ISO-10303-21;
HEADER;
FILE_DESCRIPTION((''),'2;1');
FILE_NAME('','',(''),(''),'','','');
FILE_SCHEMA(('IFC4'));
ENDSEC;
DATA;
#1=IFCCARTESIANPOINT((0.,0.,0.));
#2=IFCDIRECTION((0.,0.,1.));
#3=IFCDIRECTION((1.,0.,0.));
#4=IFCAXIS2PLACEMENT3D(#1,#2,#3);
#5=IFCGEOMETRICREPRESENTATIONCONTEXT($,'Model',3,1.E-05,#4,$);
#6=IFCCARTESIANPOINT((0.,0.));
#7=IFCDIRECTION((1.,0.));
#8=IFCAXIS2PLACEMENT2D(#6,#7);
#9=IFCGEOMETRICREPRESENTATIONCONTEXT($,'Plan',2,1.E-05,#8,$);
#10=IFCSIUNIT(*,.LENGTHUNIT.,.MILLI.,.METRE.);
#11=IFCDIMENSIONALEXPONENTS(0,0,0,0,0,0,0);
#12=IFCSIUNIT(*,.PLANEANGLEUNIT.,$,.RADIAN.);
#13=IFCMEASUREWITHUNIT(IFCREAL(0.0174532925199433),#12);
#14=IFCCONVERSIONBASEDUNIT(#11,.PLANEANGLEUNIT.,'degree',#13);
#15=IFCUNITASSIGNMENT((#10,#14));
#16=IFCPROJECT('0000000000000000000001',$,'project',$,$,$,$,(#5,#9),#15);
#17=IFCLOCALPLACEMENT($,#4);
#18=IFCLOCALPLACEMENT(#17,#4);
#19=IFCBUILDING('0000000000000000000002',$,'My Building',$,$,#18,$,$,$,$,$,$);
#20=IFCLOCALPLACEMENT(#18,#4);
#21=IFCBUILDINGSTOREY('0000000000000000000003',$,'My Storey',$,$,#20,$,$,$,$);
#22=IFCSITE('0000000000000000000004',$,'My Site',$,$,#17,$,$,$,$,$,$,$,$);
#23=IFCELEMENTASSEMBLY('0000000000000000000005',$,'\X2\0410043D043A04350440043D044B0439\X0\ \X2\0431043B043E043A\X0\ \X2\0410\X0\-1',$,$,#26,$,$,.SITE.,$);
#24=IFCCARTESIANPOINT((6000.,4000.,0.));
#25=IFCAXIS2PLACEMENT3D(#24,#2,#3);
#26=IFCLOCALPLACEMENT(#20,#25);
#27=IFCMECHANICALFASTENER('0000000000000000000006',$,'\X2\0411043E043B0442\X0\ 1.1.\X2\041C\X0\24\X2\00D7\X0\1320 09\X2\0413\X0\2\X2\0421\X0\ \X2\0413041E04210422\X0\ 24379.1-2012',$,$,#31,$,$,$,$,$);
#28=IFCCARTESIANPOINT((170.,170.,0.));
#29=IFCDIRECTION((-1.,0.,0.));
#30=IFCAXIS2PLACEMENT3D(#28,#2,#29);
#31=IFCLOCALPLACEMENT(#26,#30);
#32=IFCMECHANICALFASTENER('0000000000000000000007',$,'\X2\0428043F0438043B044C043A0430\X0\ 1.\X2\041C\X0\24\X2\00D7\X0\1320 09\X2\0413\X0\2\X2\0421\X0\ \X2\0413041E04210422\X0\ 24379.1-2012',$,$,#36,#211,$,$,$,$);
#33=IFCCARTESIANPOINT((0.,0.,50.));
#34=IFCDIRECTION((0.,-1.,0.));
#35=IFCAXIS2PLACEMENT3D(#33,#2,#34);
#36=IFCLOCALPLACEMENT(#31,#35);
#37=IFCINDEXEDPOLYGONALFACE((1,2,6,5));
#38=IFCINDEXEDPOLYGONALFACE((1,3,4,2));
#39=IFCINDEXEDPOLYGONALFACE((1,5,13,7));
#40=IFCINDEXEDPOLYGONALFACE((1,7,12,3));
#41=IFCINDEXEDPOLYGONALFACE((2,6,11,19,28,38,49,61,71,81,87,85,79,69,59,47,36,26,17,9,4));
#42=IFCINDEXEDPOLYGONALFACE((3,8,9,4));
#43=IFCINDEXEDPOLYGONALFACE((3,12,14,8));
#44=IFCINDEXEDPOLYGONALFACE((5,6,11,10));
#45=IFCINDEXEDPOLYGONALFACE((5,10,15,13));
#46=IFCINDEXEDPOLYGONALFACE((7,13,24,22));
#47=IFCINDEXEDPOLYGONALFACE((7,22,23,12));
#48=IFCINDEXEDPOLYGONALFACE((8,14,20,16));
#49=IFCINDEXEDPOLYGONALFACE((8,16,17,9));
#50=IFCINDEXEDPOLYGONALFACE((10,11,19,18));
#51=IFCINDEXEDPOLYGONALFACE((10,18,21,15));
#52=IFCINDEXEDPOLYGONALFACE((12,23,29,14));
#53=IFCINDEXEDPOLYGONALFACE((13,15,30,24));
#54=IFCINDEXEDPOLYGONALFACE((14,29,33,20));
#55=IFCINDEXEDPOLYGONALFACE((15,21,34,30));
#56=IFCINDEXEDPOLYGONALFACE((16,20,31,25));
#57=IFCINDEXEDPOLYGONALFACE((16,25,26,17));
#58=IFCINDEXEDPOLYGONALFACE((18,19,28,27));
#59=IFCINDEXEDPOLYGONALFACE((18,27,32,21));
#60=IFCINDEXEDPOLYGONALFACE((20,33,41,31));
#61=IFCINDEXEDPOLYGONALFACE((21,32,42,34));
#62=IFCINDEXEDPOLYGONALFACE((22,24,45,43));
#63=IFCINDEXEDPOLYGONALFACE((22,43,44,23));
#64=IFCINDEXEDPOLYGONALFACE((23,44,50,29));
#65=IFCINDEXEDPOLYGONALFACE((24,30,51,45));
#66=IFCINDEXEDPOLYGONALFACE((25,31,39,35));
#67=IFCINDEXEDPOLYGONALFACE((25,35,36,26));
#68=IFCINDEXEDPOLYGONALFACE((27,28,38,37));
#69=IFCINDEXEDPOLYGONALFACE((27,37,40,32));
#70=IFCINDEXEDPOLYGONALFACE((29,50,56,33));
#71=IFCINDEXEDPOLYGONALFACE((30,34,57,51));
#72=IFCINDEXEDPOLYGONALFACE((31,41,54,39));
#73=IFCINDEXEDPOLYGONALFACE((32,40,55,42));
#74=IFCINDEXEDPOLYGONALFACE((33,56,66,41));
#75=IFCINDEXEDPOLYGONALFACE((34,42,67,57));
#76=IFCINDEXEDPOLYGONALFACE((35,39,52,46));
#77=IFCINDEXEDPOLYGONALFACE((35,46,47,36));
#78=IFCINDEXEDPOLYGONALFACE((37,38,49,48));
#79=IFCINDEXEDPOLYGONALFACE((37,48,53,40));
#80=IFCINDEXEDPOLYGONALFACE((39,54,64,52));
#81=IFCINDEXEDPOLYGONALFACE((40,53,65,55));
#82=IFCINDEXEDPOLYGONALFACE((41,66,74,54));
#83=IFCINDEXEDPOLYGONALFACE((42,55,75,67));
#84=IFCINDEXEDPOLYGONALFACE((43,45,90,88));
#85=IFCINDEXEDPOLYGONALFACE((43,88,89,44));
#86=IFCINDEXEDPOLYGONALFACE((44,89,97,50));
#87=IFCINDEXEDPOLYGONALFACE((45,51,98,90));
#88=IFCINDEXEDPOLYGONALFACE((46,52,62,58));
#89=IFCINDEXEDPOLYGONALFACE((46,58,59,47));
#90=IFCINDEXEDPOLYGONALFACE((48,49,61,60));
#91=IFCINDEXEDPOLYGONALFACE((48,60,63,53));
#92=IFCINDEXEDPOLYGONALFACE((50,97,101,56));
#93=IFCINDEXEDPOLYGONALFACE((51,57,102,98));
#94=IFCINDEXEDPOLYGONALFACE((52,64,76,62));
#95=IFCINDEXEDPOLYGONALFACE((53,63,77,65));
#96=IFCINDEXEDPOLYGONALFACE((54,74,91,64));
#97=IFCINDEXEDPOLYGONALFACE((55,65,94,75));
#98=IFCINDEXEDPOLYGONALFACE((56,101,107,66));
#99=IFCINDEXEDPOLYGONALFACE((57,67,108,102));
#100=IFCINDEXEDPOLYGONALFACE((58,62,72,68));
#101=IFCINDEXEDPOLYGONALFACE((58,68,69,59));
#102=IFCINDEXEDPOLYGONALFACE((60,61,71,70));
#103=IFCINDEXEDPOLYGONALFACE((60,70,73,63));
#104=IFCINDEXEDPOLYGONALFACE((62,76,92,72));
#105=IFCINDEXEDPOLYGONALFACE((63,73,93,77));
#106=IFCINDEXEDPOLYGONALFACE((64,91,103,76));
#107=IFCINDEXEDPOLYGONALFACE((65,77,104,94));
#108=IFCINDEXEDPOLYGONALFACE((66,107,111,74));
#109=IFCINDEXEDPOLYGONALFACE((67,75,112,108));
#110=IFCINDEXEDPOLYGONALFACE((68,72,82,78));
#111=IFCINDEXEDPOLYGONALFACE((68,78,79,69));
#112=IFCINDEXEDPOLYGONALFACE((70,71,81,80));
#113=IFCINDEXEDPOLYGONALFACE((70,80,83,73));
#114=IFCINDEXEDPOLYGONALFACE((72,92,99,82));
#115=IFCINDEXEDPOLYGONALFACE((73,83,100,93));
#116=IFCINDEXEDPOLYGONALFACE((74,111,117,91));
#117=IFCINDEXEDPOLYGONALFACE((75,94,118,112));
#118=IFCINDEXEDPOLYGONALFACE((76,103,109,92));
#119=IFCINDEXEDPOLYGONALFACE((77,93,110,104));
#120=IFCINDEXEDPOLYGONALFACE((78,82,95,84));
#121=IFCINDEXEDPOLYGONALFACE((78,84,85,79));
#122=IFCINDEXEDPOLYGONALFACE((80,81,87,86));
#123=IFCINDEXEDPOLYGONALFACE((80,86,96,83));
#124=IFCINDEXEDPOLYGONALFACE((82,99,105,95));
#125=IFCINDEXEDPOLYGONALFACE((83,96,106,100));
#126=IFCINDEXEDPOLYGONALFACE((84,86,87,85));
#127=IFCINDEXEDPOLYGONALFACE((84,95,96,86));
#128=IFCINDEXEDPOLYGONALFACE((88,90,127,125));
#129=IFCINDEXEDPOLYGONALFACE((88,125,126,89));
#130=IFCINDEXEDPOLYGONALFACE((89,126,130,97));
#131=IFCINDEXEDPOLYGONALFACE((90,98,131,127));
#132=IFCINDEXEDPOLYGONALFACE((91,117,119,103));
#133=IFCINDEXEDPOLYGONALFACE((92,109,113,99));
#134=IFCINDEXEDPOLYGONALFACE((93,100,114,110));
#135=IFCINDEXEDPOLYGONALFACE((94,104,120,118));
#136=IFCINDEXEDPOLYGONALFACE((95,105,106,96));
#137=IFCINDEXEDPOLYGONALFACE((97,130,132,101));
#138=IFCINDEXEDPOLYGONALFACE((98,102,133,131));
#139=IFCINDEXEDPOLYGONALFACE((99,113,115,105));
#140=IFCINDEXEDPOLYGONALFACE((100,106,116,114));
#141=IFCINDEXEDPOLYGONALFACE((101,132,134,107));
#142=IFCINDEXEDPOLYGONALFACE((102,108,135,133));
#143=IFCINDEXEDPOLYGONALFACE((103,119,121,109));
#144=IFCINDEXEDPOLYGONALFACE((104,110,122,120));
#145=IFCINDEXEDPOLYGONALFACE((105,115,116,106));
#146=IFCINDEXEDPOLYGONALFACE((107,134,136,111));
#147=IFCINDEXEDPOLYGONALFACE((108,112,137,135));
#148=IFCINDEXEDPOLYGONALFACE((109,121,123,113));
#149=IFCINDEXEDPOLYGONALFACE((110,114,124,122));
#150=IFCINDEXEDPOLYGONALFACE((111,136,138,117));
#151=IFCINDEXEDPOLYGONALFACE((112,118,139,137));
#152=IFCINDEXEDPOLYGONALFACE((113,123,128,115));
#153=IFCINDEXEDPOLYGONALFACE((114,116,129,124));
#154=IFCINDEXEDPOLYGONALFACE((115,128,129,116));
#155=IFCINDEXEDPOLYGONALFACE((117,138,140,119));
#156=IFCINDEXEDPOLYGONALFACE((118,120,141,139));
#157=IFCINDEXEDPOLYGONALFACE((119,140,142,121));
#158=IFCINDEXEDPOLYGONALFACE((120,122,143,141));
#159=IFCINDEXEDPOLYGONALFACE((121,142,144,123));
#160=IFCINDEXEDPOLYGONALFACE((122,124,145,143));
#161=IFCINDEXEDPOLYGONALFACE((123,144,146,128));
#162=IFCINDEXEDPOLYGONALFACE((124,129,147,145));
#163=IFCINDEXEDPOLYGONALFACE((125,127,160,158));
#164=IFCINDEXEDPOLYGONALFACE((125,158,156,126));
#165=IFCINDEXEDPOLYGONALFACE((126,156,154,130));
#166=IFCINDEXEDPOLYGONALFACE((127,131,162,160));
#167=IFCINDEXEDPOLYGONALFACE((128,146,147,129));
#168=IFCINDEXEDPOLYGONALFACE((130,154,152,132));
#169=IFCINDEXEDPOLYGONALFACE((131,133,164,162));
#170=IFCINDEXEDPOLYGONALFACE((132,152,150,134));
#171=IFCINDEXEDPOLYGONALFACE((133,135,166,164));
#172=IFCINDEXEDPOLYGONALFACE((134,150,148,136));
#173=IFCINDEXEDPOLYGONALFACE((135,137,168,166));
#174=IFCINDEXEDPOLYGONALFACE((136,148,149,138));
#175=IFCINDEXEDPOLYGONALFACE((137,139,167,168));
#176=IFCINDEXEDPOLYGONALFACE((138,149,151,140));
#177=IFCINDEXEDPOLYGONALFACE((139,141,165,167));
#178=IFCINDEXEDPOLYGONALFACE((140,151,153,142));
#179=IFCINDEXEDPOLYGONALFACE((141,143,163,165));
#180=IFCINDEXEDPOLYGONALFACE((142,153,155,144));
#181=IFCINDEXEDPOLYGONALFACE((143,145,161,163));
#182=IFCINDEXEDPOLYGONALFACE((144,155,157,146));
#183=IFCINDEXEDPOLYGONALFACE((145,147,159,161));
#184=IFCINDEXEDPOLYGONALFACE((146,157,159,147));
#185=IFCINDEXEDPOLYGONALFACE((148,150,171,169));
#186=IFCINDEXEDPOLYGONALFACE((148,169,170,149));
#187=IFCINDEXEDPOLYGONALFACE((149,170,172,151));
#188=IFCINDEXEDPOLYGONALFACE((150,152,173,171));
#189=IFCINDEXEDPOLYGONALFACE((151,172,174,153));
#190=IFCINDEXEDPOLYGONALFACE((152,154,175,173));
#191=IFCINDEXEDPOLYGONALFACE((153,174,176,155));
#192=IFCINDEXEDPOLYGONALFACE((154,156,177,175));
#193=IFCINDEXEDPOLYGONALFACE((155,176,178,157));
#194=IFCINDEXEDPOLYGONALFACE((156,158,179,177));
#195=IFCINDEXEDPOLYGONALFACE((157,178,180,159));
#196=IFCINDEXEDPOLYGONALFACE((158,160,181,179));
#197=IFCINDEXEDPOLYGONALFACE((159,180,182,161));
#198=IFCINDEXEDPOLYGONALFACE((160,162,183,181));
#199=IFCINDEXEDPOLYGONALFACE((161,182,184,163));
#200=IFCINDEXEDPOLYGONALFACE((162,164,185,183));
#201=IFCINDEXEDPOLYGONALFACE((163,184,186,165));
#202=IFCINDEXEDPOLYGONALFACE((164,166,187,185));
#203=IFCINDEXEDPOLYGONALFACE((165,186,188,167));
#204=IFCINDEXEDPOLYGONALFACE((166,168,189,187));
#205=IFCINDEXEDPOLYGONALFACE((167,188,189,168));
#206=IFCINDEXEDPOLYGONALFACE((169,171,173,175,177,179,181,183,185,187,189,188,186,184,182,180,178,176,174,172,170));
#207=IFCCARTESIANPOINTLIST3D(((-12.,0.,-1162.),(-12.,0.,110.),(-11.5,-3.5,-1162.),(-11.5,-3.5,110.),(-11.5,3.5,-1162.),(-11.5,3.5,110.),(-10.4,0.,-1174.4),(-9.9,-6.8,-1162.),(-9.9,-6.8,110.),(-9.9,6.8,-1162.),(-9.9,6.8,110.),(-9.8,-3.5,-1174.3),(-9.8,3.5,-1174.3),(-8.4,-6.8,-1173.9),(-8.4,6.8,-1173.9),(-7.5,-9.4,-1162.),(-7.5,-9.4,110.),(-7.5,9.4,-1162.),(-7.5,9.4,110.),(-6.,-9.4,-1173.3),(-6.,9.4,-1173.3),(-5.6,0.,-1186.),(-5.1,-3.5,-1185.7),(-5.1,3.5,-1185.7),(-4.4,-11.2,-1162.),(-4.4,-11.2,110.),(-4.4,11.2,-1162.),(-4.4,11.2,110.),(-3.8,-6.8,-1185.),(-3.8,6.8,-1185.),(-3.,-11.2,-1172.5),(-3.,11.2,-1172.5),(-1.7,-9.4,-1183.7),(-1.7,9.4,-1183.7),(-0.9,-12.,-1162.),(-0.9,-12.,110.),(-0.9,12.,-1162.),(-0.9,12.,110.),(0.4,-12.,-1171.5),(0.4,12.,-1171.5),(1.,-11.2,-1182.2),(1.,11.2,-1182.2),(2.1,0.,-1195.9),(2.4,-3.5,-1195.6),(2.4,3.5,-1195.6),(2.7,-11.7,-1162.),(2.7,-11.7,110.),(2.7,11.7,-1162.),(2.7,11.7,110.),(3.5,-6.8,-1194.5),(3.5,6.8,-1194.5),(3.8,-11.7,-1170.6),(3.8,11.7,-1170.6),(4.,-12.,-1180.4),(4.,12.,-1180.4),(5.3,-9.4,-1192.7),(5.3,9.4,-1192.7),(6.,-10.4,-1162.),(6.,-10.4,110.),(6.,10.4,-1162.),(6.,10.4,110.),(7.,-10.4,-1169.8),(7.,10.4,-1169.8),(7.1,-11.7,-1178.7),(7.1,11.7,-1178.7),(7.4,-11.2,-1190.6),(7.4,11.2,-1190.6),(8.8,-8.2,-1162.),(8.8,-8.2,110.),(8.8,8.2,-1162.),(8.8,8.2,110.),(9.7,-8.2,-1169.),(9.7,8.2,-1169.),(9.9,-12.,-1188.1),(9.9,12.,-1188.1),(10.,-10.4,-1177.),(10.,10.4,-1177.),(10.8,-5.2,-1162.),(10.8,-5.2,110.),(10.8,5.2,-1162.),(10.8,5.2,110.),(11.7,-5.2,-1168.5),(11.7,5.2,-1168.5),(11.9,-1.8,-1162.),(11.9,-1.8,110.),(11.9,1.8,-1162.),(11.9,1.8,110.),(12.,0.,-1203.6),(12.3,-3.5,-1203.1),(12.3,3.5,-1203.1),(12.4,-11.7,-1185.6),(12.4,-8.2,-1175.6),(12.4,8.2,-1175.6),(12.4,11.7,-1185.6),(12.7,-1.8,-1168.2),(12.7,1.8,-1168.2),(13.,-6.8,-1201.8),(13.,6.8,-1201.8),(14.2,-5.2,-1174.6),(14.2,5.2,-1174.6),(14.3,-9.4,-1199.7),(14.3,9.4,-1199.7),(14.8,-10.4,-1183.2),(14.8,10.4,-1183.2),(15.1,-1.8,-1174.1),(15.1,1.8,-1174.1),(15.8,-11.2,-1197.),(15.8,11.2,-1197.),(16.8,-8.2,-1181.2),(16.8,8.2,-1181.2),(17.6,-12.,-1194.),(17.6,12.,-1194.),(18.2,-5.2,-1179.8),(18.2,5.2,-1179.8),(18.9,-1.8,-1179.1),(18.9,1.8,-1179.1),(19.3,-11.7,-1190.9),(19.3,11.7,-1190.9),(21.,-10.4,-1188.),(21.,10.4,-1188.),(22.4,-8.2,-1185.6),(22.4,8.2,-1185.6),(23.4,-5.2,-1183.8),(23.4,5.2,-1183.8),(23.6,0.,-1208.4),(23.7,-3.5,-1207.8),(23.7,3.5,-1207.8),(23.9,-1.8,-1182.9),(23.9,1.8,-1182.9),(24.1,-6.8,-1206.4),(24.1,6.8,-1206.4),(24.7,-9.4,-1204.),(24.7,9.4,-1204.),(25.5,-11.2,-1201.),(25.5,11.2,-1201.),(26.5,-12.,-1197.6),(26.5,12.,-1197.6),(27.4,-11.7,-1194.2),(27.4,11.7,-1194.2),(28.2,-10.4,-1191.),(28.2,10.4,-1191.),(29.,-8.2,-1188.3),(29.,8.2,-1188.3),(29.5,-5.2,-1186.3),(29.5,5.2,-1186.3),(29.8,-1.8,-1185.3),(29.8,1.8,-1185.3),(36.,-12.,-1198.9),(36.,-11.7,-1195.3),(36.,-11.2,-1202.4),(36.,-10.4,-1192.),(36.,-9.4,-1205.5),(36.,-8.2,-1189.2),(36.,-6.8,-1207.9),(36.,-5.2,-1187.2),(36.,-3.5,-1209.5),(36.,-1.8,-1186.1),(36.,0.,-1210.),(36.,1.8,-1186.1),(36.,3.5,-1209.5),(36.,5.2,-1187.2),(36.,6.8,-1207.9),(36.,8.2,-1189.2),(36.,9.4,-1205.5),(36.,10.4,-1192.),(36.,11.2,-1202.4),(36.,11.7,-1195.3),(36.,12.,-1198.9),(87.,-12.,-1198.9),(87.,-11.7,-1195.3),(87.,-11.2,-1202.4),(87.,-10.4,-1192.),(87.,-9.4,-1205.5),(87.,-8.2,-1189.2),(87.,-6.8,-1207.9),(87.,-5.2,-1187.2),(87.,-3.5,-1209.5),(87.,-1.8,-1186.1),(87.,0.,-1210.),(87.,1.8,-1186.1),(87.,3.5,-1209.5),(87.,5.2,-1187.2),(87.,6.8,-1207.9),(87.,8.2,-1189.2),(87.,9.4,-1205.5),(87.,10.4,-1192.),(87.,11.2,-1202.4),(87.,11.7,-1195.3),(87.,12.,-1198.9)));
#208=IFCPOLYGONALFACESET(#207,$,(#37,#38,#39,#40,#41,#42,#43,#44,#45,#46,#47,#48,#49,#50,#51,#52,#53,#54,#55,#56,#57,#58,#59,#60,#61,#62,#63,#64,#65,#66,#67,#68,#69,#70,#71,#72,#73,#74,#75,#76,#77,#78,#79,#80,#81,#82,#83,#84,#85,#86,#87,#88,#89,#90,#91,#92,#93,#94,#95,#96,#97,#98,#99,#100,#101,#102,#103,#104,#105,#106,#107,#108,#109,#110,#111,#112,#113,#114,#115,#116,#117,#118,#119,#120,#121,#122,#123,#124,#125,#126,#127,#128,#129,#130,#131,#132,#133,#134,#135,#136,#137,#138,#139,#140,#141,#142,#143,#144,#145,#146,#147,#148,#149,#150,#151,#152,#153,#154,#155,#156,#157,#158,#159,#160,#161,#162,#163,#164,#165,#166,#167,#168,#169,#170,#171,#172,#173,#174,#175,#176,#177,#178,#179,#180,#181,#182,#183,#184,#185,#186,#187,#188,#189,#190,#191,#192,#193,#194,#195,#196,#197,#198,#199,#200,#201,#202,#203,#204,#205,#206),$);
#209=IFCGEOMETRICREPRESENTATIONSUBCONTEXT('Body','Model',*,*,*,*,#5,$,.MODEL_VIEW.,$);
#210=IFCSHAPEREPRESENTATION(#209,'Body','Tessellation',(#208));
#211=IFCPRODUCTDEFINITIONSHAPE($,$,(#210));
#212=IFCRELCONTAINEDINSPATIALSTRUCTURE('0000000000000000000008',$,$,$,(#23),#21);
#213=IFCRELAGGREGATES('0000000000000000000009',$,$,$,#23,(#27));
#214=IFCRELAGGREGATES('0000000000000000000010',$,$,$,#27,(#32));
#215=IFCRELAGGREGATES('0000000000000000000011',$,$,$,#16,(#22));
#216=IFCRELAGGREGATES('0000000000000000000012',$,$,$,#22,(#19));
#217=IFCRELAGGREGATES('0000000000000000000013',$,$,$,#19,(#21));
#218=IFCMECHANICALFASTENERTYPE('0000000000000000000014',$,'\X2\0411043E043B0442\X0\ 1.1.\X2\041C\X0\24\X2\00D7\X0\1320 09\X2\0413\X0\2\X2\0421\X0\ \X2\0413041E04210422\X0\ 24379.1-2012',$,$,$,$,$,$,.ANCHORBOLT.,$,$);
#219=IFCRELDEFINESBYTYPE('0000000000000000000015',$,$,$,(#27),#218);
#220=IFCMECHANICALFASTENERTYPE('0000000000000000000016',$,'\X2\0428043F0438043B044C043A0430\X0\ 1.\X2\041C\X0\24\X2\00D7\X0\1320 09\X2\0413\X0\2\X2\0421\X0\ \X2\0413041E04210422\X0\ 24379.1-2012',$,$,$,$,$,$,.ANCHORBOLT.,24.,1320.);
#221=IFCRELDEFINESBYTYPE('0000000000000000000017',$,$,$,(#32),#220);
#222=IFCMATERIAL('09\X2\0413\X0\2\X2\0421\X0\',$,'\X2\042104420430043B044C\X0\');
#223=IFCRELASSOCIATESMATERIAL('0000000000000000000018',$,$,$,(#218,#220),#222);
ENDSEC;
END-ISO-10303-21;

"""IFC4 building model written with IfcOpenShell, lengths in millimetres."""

from ifc_helpers import new_model, entity, si_unit, converted_unit, frame, origin_with_axes, origin_2d_with_axis, place, context, subcontext, project, spatial, source, transform, mapped, material, type_object, type_shapes, element, aggregate, save


model = new_model("IFC4")

# Units and contexts
model_context = context("Model", 3, precision=1e-05, world=origin_with_axes())
plan_context = context("Plan", 2, precision=1e-05, world=origin_2d_with_axis())
body_context = subcontext(model_context, "Body", "Model", "MODEL_VIEW")
ifc_project = project(units=[si_unit("LENGTHUNIT", "METRE", prefix="MILLI"), converted_unit("PLANEANGLEUNIT", "degree", entity("IfcReal", 0.0174532925199433), si_unit("PLANEANGLEUNIT", "RADIAN"), dimensions=[0, 0, 0, 0, 0, 0, 0])], contexts=[model_context, plan_context])

# Site, building, storey
site_placement = place(None, origin_with_axes())
site = spatial("IfcSite", under=ifc_project, at=site_placement, Name="My Site")
building_placement = place(site_placement, origin_with_axes())
building = spatial("IfcBuilding", under=site, at=building_placement, Name="My Building")
storey_placement = place(building_placement, origin_with_axes())
storey = spatial("IfcBuildingStorey", under=building, at=storey_placement, Name="My Storey")

# Element assembly, mechanical fasteners
assembly_1_placement = place(storey_placement, frame((6000.0, 4000.0, 0.0), z_axis=(0.0, 0.0, 1.0), x_axis=(1.0, 0.0, 0.0)))
assembly_1 = element("IfcElementAssembly", 1, at=assembly_1_placement, inside=storey, Name="Анкерный блок А-1", AssemblyPlace="SITE")
ifc_material_1 = material(Name="09Г2С", Category="Сталь")
mechanical_fastener_type_1 = type_object("IfcMechanicalFastenerType", Name="Болт 1.1.М24×1320 09Г2С ГОСТ 24379.1-2012", PredefinedType="ANCHORBOLT", material=ifc_material_1)
mechanical_fastener_type_2 = type_object("IfcMechanicalFastenerType", Name="Шпилька 1.М24×1320 09Г2С ГОСТ 24379.1-2012", NominalDiameter=24.0, NominalLength=1320.0, PredefinedType="ANCHORBOLT", material=ifc_material_1)
shared_shape_1 = source(frame((0.0, 0.0, 110.0), z_axis=(0.0, 0.0, 1.0), x_axis=(1.0, 0.0, 0.0)), body_context, "Body", "AdvancedSweptSolid", [
    entity("IfcSweptDiskSolid", entity("IfcIndexedPolyCurve", entity("IfcCartesianPointList3D", [[0.0, 0.0, 0.0], [0.0, 0.0, -1272.0], [10.5, 0.0, -1297.5], [36.0, 0.0, -1308.0], [87.0, 0.0, -1308.0]]), [entity("IfcLineIndex", [1, 2]), entity("IfcArcIndex", [2, 3, 4]), entity("IfcLineIndex", [4, 5])]), 12.0),
])
type_shapes(mechanical_fastener_type_2, [shared_shape_1])
mechanical_fastener_1_placement = place(assembly_1_placement, frame((170.0, 170.0, 0.0), z_axis=(0.0, 0.0, 1.0), x_axis=(-1.0, 0.0, 0.0)))
mechanical_fastener_1 = element("IfcMechanicalFastener", 2, at=mechanical_fastener_1_placement, type_object=mechanical_fastener_type_1, Name="Болт 1.1.М24×1320 09Г2С ГОСТ 24379.1-2012")
aggregate(assembly_1, [mechanical_fastener_1])
mechanical_fastener_2_placement = place(mechanical_fastener_1_placement, frame((0.0, 0.0, 50.0), z_axis=(0.0, 0.0, 1.0), x_axis=(0.0, -1.0, 0.0)))
mechanical_fastener_2 = element("IfcMechanicalFastener", 3, at=mechanical_fastener_2_placement, type_object=mechanical_fastener_type_2, Name="Шпилька 1.М24×1320 09Г2С ГОСТ 24379.1-2012", context=body_context, shape_type="MappedRepresentation", body=[
    mapped(shared_shape_1, transform((0.0, 0.0, 0.0), x_axis=(1.0, 0.0, 0.0), y_axis=(0.0, 1.0, 0.0), z_axis=(0.0, 0.0, 1.0), scale=1.0)),
])

aggregate(mechanical_fastener_1, [mechanical_fastener_2])

save(model, "model.ifc")
